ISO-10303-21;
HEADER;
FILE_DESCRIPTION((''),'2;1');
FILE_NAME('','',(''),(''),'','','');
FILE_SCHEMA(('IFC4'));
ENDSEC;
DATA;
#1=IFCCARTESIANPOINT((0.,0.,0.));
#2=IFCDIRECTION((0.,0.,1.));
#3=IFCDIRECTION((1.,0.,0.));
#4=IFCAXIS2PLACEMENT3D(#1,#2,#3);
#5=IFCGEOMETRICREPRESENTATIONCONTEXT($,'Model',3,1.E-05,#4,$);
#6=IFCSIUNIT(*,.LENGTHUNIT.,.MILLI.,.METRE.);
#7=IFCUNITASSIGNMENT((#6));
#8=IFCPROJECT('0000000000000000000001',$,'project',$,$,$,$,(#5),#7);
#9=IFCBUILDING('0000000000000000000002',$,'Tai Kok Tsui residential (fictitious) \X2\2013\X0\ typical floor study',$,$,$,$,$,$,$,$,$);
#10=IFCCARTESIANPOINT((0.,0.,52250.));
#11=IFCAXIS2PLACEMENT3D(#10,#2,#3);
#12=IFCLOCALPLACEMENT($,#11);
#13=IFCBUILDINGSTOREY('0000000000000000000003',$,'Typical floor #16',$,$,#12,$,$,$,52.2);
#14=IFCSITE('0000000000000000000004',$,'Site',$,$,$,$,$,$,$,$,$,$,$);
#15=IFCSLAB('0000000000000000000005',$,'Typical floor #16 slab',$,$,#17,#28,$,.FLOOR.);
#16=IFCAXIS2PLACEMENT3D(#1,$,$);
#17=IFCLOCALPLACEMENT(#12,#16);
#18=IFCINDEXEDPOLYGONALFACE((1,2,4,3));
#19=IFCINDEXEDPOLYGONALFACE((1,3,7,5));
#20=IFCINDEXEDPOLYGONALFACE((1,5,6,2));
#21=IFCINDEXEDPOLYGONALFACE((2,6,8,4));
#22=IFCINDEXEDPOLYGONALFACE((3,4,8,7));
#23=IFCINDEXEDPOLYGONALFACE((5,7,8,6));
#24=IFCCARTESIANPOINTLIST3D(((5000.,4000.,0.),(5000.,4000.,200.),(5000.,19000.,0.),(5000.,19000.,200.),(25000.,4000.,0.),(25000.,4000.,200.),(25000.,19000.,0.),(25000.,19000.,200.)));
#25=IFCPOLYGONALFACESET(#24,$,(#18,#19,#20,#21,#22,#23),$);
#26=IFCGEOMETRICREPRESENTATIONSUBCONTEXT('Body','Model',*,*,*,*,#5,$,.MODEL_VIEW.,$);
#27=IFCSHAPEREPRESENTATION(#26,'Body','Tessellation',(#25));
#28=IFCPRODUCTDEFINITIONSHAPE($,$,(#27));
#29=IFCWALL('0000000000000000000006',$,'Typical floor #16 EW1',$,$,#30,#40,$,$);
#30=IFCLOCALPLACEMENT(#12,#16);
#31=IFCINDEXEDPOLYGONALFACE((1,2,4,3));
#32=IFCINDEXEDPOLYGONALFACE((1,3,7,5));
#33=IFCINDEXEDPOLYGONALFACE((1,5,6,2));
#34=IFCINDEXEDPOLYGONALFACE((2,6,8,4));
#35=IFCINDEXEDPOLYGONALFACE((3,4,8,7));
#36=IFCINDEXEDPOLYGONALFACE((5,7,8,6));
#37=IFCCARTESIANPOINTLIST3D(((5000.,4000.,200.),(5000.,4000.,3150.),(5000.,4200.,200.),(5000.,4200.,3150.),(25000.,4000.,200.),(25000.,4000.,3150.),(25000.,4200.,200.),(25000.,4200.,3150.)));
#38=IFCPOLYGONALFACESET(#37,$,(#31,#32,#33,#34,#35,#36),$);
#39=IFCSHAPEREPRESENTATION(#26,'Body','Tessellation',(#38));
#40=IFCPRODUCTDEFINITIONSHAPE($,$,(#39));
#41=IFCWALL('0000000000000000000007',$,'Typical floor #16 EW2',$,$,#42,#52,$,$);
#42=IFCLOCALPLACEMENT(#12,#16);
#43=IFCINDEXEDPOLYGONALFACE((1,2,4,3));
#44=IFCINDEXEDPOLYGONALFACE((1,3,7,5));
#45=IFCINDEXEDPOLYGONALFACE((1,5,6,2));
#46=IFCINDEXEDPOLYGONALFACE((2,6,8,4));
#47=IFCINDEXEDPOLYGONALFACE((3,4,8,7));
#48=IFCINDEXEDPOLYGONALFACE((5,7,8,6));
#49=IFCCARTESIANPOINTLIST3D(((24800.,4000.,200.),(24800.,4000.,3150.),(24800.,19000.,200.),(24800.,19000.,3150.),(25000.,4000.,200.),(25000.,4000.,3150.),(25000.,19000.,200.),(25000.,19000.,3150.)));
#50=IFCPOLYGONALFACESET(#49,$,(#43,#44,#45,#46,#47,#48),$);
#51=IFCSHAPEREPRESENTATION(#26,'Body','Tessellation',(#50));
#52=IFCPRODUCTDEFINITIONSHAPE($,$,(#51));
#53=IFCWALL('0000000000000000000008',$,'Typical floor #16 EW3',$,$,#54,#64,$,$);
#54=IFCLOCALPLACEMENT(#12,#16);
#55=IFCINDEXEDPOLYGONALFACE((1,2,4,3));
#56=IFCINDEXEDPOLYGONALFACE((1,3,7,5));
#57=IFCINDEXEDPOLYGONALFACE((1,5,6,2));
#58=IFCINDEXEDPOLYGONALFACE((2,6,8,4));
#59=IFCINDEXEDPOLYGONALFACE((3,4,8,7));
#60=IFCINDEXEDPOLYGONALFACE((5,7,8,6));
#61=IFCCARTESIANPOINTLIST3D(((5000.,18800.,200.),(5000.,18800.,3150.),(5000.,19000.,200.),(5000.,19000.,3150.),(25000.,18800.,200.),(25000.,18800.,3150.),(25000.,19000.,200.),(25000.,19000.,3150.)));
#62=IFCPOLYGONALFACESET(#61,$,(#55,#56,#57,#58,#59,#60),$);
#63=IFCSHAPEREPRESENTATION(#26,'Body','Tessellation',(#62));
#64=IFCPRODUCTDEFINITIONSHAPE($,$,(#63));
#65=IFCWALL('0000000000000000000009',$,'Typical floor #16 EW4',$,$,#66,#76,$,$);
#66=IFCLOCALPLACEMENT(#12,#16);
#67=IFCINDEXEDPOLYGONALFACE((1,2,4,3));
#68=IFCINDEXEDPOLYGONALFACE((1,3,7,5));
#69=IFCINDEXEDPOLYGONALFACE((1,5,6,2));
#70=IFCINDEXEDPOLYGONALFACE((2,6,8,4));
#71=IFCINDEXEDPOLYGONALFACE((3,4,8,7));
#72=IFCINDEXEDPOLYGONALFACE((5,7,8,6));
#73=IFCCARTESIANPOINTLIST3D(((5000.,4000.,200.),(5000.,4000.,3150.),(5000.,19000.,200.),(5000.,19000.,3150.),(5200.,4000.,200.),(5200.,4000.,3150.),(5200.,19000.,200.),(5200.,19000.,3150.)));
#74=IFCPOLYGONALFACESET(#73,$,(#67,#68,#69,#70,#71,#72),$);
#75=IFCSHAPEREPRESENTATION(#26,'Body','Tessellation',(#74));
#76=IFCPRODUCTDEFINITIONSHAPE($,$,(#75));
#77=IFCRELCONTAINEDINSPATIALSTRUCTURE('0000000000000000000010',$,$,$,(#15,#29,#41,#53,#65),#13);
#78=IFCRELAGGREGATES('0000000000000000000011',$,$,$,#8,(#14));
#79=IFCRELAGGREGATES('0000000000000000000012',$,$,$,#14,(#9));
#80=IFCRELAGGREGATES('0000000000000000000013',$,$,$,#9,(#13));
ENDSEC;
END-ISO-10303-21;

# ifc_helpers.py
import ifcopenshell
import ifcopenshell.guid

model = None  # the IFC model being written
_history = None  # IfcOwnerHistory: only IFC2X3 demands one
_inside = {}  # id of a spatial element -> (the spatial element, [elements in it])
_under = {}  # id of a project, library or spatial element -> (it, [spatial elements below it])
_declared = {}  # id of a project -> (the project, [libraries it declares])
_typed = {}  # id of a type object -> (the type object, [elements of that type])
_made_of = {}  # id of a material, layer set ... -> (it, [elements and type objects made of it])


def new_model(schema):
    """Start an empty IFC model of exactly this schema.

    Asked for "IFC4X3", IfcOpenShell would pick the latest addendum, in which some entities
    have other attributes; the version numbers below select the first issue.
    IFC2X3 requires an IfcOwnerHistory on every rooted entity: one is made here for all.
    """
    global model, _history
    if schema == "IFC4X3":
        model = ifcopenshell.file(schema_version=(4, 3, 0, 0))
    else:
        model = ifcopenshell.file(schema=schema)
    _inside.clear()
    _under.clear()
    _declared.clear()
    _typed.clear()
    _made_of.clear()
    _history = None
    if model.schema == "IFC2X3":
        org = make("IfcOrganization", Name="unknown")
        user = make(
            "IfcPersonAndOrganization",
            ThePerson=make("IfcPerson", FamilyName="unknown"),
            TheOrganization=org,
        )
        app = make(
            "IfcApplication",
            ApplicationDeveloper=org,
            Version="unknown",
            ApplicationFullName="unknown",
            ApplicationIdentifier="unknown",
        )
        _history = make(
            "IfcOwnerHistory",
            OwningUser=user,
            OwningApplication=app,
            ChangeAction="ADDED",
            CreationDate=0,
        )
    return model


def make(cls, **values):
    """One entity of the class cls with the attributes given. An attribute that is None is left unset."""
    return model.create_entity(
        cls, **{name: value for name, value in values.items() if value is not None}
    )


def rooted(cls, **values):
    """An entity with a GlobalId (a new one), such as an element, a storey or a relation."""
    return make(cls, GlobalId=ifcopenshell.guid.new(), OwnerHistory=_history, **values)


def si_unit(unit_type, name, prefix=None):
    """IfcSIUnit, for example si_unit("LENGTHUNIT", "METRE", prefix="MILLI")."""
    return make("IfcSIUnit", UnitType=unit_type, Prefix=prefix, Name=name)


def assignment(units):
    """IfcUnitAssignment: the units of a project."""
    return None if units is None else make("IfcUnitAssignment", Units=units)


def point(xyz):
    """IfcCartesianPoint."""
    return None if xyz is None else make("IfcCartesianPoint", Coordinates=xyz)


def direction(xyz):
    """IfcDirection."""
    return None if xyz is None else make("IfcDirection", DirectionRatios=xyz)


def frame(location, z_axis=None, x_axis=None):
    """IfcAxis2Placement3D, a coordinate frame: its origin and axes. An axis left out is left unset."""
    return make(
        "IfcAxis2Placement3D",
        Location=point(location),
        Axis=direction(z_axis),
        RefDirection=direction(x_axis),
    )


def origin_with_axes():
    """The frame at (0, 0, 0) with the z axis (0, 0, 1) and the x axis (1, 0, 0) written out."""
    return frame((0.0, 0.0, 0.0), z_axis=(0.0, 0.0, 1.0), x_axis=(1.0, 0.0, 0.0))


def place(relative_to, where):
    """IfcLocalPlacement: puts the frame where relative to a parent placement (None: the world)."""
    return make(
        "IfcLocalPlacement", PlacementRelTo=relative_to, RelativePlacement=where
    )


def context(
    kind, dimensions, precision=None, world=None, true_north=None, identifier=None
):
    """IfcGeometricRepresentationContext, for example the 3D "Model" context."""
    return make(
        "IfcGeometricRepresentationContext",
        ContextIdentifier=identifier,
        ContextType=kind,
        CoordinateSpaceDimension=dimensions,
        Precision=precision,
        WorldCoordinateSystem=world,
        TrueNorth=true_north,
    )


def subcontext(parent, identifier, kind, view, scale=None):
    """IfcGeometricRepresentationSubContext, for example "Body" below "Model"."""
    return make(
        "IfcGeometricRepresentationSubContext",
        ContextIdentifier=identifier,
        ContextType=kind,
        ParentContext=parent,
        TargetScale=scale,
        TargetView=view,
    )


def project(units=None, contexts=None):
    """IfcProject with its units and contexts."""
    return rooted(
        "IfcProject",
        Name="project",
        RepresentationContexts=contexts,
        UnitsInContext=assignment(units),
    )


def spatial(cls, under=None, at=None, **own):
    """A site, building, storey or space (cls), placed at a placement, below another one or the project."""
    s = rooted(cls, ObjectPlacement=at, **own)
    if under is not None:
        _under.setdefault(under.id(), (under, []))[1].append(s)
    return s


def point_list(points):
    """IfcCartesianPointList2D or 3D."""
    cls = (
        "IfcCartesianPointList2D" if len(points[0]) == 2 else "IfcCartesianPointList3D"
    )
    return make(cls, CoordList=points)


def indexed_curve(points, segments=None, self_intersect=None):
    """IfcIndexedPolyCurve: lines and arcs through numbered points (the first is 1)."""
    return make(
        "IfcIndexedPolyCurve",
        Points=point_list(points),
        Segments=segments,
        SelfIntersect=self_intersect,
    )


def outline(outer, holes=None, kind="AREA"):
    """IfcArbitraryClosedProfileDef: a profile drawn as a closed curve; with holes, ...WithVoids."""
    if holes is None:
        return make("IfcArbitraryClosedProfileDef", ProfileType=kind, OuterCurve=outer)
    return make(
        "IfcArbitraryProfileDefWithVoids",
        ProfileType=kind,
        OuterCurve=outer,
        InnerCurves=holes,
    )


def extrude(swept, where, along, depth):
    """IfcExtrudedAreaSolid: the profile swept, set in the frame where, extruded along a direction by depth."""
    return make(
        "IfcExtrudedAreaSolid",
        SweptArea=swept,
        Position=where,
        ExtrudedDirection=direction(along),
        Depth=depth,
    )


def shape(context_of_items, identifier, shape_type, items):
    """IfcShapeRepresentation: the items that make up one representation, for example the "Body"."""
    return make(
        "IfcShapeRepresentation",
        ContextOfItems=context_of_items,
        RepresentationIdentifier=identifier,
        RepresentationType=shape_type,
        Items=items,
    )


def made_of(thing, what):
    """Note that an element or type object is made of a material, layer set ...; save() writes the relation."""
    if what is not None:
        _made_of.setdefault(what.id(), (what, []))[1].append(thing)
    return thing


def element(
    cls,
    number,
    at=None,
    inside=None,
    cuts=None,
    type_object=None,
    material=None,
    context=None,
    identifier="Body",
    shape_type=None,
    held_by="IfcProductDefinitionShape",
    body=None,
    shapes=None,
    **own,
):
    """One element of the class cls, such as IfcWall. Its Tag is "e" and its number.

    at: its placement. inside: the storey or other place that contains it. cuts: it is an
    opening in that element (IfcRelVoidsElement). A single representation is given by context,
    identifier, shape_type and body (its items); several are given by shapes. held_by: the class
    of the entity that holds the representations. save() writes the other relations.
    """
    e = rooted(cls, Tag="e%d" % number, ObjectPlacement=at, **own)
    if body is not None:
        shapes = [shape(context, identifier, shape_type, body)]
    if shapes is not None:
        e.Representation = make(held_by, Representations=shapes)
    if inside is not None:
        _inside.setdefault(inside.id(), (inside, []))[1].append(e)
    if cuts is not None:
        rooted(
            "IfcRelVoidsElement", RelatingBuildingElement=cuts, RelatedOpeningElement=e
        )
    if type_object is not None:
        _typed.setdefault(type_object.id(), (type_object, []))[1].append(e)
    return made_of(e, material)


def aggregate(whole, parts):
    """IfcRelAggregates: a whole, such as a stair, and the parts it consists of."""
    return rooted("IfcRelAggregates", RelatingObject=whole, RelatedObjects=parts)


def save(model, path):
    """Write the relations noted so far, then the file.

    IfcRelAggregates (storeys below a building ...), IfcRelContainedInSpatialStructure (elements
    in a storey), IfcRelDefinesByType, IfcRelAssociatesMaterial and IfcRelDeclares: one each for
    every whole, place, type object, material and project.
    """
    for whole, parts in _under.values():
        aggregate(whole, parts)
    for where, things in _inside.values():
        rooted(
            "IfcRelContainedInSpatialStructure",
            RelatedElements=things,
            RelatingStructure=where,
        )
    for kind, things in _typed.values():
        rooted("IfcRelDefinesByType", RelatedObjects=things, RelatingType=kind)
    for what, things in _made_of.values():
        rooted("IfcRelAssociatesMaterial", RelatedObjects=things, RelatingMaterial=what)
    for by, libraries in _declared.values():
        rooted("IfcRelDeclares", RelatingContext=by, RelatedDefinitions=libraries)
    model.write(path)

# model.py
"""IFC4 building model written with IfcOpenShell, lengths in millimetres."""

from ifc_helpers import new_model, si_unit, frame, origin_with_axes, place, context, subcontext, project, spatial, indexed_curve, outline, extrude, element, save


model = new_model("IFC4")

# Units and contexts
model_context = context("Model", 3, precision=1e-05, world=origin_with_axes())
body_context = subcontext(model_context, "Body", "Model", "MODEL_VIEW")
ifc_project = project(units=[si_unit("LENGTHUNIT", "METRE", prefix="MILLI")], contexts=[model_context])

# Site, building, storey
site = spatial("IfcSite", under=ifc_project, Name="Site")
building = spatial("IfcBuilding", under=site, Name="Tai Kok Tsui residential (fictitious) – typical floor study")
storey_placement = place(None, frame((0.0, 0.0, 52250.0), z_axis=(0.0, 0.0, 1.0), x_axis=(1.0, 0.0, 0.0)))
storey = spatial("IfcBuildingStorey", under=building, at=storey_placement, Name="Typical floor #16", Elevation=52.2)

# Slab
slab_placement = place(storey_placement, origin_with_axes())
element("IfcSlab", 1, at=slab_placement, inside=storey, Name="Typical floor #16 slab", PredefinedType="FLOOR", context=body_context, shape_type="SweptSolid", body=[
    extrude(outline(indexed_curve([(5000.0, 4000.0), (25000.0, 4000.0), (25000.0, 19000.0), (5000.0, 19000.0)])), None, (0.0, 0.0, 1.0), 200.0),
])

# Walls
wall_1_placement = place(storey_placement, frame((5000.0, 4000.0, 200.0), z_axis=(0.0, 0.0, 1.0), x_axis=(1.0, 0.0, 0.0)))
element("IfcWall", 2, at=wall_1_placement, inside=storey, Name="Typical floor #16 EW1", context=body_context, shape_type="SweptSolid", body=[
    extrude(outline(indexed_curve([(0.0, 0.0), (0.0, 200.0), (20000.0, 200.0), (20000.0, 0.0), (0.0, 0.0)], self_intersect=False)), origin_with_axes(), (0.0, 0.0, 1.0), 2950.0),
])
wall_2_placement = place(storey_placement, frame((25000.0, 4000.0, 200.0), z_axis=(0.0, 0.0, 1.0), x_axis=(0.0, 1.0, 0.0)))
element("IfcWall", 3, at=wall_2_placement, inside=storey, Name="Typical floor #16 EW2", context=body_context, shape_type="SweptSolid", body=[
    extrude(outline(indexed_curve([(0.0, 0.0), (0.0, 200.0), (15000.0, 200.0), (15000.0, 0.0), (0.0, 0.0)], self_intersect=False)), origin_with_axes(), (0.0, 0.0, 1.0), 2950.0),
])
wall_3_placement = place(storey_placement, frame((25000.0, 19000.0, 200.0), z_axis=(0.0, 0.0, 1.0), x_axis=(-1.0, 0.0, 0.0)))
element("IfcWall", 4, at=wall_3_placement, inside=storey, Name="Typical floor #16 EW3", context=body_context, shape_type="SweptSolid", body=[
    extrude(outline(indexed_curve([(0.0, 0.0), (0.0, 200.0), (20000.0, 200.0), (20000.0, 0.0), (0.0, 0.0)], self_intersect=False)), origin_with_axes(), (0.0, 0.0, 1.0), 2950.0),
])
wall_4_placement = place(storey_placement, frame((5000.0, 19000.0, 200.0), z_axis=(0.0, 0.0, 1.0), x_axis=(0.0, -1.0, 0.0)))
element("IfcWall", 5, at=wall_4_placement, inside=storey, Name="Typical floor #16 EW4", context=body_context, shape_type="SweptSolid", body=[
    extrude(outline(indexed_curve([(0.0, 0.0), (0.0, 200.0), (15000.0, 200.0), (15000.0, 0.0), (0.0, 0.0)], self_intersect=False)), origin_with_axes(), (0.0, 0.0, 1.0), 2950.0),
])

save(model, "model.ifc")
